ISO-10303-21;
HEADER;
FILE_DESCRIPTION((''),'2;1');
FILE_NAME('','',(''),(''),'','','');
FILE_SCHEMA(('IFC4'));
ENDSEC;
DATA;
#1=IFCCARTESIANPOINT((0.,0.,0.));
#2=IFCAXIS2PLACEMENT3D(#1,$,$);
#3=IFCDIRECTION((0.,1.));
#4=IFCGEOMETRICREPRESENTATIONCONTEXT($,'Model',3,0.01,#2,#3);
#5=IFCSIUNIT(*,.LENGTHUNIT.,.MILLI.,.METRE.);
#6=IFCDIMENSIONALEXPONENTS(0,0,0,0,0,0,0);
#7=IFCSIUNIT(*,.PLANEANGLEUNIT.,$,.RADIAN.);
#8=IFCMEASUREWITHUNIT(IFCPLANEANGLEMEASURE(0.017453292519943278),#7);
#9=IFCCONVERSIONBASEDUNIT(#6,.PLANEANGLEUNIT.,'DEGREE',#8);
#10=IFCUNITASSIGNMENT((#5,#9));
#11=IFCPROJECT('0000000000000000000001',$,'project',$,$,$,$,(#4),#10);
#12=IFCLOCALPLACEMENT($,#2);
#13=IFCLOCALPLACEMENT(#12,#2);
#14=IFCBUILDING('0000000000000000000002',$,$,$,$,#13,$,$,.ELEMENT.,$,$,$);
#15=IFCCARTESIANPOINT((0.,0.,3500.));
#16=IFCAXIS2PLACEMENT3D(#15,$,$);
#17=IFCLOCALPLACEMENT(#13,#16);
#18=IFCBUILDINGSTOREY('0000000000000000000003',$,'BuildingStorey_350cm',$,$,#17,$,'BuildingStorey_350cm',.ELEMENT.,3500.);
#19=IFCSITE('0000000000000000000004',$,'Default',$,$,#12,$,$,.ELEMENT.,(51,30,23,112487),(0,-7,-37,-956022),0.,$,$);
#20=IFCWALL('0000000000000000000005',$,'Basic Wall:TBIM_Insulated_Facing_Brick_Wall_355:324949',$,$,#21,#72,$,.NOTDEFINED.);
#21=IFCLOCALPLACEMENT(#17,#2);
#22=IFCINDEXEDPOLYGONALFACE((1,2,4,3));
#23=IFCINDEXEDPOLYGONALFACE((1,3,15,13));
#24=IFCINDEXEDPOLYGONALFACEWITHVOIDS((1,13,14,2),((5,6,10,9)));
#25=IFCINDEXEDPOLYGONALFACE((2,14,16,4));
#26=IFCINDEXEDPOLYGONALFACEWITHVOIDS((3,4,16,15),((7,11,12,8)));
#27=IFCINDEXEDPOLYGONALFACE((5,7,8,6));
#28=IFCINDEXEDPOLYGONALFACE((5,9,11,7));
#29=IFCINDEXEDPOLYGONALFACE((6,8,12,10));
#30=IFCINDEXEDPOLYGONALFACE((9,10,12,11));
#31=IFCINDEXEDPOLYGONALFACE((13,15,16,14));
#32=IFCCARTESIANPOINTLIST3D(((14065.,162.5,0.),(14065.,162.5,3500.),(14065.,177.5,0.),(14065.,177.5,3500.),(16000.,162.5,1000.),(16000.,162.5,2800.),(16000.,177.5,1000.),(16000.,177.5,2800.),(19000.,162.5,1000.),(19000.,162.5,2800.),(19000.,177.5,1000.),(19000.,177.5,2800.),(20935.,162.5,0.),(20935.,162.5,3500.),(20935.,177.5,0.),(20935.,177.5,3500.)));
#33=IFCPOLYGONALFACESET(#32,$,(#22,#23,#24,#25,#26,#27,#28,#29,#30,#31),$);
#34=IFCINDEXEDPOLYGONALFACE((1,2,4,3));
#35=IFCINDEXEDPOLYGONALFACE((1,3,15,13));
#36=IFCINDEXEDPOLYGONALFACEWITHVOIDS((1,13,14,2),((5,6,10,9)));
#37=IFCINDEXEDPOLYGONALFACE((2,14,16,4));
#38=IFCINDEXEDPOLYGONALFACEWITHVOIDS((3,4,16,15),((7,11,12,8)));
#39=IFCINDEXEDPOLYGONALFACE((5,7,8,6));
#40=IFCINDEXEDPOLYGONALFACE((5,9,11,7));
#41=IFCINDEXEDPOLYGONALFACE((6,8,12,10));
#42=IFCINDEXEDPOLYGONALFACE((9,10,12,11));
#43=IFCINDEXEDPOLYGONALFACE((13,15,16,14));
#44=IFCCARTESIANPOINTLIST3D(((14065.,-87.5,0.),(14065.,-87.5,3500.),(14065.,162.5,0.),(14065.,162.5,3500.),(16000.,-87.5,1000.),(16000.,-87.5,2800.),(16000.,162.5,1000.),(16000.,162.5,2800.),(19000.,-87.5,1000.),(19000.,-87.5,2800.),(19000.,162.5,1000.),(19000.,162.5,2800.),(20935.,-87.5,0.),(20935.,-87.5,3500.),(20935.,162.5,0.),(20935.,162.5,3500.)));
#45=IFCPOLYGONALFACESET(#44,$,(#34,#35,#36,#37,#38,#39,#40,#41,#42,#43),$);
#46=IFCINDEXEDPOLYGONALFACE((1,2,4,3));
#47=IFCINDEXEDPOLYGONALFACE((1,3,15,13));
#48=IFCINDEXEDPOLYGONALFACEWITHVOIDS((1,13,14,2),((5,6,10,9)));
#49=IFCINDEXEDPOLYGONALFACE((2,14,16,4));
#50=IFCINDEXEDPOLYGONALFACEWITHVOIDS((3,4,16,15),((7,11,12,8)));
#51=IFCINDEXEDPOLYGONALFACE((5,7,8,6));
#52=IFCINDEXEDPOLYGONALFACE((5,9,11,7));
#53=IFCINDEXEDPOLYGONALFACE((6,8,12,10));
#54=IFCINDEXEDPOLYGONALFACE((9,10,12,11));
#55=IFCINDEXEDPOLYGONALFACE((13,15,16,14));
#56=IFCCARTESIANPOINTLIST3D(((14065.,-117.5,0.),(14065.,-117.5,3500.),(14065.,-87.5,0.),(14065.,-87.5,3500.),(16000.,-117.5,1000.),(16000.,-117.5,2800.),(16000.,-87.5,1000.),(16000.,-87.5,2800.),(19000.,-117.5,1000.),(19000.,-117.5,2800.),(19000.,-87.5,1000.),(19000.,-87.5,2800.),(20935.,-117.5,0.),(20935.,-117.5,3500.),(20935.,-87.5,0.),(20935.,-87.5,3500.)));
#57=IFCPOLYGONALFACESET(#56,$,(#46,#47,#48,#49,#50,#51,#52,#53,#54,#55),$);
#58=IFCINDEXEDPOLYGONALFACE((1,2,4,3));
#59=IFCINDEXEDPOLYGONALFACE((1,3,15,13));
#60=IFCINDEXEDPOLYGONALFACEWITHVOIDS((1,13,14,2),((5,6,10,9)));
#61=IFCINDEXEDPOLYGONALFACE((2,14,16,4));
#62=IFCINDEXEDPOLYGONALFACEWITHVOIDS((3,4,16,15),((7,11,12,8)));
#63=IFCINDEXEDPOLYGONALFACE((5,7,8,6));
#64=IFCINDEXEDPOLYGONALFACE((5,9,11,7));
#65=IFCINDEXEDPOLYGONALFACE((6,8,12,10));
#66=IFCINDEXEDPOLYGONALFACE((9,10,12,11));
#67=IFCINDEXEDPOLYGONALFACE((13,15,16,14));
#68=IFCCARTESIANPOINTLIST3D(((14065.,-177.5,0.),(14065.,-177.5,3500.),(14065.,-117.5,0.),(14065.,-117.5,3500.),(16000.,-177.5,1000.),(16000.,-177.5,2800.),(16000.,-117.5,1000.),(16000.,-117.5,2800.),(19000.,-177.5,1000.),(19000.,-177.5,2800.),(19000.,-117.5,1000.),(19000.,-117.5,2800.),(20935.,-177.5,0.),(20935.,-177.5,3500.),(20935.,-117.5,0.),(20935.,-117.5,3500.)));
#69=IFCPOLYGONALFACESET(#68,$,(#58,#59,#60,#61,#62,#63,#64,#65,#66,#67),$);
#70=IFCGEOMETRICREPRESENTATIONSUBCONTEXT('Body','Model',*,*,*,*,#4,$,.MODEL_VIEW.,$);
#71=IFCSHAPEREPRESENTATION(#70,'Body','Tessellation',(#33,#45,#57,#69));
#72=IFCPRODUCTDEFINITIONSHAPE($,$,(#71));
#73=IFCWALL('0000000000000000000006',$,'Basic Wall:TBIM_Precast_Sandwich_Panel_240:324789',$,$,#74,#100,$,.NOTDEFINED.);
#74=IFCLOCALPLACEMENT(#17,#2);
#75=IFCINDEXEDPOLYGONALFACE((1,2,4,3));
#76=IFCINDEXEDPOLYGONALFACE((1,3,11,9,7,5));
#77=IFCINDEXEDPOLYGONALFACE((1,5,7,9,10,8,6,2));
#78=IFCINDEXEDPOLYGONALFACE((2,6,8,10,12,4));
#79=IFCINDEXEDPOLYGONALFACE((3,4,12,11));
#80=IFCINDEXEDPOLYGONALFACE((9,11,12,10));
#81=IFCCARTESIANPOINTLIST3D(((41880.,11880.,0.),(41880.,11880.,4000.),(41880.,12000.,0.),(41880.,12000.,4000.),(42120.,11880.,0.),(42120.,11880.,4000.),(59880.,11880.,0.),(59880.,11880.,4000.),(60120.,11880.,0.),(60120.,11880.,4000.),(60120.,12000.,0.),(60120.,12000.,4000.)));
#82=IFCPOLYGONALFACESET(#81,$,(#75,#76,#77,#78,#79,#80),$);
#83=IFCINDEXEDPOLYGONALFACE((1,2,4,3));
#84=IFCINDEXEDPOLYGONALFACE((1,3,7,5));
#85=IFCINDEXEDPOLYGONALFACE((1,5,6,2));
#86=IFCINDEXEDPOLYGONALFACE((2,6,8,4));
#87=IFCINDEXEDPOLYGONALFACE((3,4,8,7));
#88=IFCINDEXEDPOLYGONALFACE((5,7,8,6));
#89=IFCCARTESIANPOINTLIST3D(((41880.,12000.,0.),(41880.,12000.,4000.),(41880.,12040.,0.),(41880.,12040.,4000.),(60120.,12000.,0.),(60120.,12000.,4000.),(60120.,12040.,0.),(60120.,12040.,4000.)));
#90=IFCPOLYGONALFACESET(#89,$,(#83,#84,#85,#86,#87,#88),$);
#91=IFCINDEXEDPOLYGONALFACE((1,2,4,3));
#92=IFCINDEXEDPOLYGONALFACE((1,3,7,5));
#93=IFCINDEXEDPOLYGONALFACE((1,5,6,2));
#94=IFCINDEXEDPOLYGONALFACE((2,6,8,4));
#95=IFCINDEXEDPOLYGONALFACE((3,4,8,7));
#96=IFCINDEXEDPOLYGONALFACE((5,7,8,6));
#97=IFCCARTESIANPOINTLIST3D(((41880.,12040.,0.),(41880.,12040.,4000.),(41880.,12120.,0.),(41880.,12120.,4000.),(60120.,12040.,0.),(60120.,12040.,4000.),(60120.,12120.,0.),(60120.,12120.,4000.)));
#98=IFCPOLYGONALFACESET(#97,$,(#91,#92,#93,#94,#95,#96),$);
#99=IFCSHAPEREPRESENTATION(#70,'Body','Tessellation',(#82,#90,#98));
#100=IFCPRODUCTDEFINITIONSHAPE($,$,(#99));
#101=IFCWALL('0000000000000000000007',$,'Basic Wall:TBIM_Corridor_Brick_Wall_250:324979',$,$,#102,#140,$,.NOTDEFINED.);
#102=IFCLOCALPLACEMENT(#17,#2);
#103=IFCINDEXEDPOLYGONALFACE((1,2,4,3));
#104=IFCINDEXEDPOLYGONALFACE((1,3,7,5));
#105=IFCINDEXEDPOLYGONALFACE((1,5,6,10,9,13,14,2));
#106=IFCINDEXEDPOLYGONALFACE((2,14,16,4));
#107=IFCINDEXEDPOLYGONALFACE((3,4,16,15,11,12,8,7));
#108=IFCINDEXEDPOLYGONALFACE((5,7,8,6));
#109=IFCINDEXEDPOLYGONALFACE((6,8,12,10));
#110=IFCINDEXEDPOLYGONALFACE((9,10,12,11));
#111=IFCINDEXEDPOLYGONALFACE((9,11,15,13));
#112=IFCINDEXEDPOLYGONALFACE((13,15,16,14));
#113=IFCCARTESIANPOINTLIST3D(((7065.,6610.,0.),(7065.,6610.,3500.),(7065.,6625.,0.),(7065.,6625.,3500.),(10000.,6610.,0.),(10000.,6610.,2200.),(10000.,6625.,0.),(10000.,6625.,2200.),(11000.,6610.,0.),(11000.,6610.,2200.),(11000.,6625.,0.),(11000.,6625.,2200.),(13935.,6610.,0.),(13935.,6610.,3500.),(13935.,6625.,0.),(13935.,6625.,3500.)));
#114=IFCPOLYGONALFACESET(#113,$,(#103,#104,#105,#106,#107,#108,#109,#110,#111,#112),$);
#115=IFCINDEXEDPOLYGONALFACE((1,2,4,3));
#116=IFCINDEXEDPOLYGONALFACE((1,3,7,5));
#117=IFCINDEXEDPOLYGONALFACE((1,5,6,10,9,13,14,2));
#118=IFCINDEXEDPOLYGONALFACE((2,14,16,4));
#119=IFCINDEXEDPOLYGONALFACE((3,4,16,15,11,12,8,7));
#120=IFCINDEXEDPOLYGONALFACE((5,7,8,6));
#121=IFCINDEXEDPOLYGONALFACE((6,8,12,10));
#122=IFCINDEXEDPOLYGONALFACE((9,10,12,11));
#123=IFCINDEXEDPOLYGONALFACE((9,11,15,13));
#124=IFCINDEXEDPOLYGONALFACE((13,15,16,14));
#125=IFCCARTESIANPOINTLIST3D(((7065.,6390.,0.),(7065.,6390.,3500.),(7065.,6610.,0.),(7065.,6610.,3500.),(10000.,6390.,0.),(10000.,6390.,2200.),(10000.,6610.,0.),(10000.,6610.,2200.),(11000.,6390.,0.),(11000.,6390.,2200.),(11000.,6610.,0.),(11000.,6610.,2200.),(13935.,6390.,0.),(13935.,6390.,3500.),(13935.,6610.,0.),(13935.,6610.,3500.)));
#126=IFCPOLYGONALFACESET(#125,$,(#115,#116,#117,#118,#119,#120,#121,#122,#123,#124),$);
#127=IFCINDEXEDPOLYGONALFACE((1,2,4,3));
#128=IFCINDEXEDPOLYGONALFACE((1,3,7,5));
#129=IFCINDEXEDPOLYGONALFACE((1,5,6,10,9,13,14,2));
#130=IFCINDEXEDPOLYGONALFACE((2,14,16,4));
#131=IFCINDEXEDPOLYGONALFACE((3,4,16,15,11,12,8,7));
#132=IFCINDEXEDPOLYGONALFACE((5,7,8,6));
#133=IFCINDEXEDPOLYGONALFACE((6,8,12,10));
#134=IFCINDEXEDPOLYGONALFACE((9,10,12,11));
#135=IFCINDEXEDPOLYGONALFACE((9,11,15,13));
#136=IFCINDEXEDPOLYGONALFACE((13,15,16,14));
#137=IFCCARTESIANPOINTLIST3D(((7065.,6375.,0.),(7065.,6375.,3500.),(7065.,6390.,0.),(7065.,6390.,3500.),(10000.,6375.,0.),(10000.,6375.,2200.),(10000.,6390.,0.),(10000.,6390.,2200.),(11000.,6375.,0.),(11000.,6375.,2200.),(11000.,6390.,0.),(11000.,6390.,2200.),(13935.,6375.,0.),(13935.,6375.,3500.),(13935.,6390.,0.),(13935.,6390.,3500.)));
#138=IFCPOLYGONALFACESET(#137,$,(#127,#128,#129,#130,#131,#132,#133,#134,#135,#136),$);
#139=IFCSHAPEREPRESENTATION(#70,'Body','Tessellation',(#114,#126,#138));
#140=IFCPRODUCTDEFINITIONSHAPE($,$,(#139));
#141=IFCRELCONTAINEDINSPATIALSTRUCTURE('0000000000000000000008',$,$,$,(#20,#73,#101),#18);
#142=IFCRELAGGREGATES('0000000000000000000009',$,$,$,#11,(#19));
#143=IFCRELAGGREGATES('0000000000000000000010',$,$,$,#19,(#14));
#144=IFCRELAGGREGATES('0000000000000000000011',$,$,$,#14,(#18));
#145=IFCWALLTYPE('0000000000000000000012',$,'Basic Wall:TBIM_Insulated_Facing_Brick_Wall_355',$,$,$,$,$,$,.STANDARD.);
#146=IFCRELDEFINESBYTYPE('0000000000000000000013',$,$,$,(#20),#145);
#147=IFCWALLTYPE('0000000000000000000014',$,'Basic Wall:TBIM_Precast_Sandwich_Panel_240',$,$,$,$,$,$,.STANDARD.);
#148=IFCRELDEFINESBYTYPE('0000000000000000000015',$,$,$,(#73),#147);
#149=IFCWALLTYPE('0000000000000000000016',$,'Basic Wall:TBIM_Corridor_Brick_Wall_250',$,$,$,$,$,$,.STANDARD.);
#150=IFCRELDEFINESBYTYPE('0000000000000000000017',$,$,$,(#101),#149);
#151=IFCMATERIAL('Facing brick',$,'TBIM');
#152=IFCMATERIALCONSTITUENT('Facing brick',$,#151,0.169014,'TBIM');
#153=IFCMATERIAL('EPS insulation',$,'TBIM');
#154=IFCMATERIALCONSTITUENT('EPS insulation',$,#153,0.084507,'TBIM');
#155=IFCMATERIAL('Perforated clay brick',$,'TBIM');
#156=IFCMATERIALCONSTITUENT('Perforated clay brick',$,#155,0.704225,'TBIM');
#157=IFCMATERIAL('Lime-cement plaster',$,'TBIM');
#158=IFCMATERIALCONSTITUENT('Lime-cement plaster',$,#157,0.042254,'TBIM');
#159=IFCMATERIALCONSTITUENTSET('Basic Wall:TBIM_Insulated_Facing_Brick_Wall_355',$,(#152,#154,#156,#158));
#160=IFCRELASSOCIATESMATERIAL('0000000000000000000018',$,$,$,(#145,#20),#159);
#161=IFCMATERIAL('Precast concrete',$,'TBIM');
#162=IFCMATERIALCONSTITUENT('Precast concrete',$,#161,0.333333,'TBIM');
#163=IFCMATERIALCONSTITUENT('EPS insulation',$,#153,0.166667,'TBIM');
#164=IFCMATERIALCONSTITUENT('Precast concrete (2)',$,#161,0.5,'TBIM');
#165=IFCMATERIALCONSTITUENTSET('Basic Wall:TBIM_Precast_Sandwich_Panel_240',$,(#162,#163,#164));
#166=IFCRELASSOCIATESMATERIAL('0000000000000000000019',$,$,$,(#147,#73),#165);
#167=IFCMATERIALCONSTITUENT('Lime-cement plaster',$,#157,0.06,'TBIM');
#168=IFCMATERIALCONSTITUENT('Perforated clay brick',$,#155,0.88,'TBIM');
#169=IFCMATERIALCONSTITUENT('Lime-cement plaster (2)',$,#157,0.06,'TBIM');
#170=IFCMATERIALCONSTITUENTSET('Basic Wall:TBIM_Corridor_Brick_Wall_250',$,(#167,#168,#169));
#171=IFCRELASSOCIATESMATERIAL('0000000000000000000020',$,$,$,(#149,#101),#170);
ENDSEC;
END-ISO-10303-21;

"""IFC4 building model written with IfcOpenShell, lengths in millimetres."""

from ifc_helpers import new_model, entity, si_unit, converted_unit, direction, frame, origin, place, context, subcontext, project, spatial, indexed_curve, outline, extrude, material, constituent, constituent_set, type_object, element, save


model = new_model("IFC4")

# Units and contexts
model_context = context("Model", 3, precision=0.01, world=origin(), true_north=direction((0.0, 1.0)))
body_context = subcontext(model_context, "Body", "Model", "MODEL_VIEW")
ifc_project = project(units=[si_unit("LENGTHUNIT", "METRE", prefix="MILLI"), converted_unit("PLANEANGLEUNIT", "DEGREE", entity("IfcPlaneAngleMeasure", 0.017453292519943278), si_unit("PLANEANGLEUNIT", "RADIAN"), dimensions=[0, 0, 0, 0, 0, 0, 0])], contexts=[model_context])

# Site, building, storey
site_placement = place(None, origin())
site = spatial("IfcSite", under=ifc_project, at=site_placement, Name="Default", CompositionType="ELEMENT", RefLatitude=(51, 30, 23, 112487), RefLongitude=(0, -7, -37, -956022), RefElevation=0.0)
building_placement = place(site_placement, origin())
building = spatial("IfcBuilding", under=site, at=building_placement, CompositionType="ELEMENT")
storey_placement = place(building_placement, frame((0.0, 0.0, 3500.0)))
storey = spatial("IfcBuildingStorey", under=building, at=storey_placement, Name="BuildingStorey_350cm", LongName="BuildingStorey_350cm", CompositionType="ELEMENT", Elevation=3500.0)

# Shared definitions
ifc_material_1 = material(Name="Lime-cement plaster", Category="TBIM")

# Wall, opening
ifc_material_2 = material(Name="Facing brick", Category="TBIM")
ifc_constituent_1 = constituent(ifc_material_2, Name="Facing brick", Category="TBIM", fraction=0.169014)
ifc_material_3 = material(Name="EPS insulation", Category="TBIM")
ifc_constituent_2 = constituent(ifc_material_3, Name="EPS insulation", Category="TBIM", fraction=0.084507)
ifc_material_4 = material(Name="Perforated clay brick", Category="TBIM")
ifc_constituent_3 = constituent(ifc_material_4, Name="Perforated clay brick", Category="TBIM", fraction=0.704225)
ifc_constituent_4 = constituent(ifc_material_1, Name="Lime-cement plaster", Category="TBIM", fraction=0.042254)
ifc_constituent_set_1 = constituent_set(constituents=[ifc_constituent_1, ifc_constituent_2, ifc_constituent_3, ifc_constituent_4], Name="Basic Wall:TBIM_Insulated_Facing_Brick_Wall_355")
wall_type_1 = type_object("IfcWallType", Name="Basic Wall:TBIM_Insulated_Facing_Brick_Wall_355", PredefinedType="STANDARD", material=ifc_constituent_set_1)
wall_1_placement = place(storey_placement, frame((14065.0, 0.0, 0.0)))
wall_1 = element("IfcWall", 1, at=wall_1_placement, inside=storey, type_object=wall_type_1, material=ifc_constituent_set_1, Name="Basic Wall:TBIM_Insulated_Facing_Brick_Wall_355:324949", PredefinedType="NOTDEFINED", context=body_context, shape_type="SweptSolid", body=[
    extrude(outline(indexed_curve([(-1750.0, -3435.0), (1750.0, -3435.0), (1750.0, 3435.0), (-1750.0, 3435.0), (-1750.0, -3435.0)], self_intersect=False), holes=[indexed_curve([(-750.0, -1500.0), (-750.0, 1500.0), (1050.0, 1500.0), (1050.0, -1500.0), (-750.0, -1500.0)], self_intersect=False)]), frame((3435.0, 162.5, 1750.0), z_axis=(0.0, 1.0, 0.0), x_axis=(0.0, 0.0, 1.0)), (0.0, 0.0, 1.0), 15.0),
    extrude(outline(indexed_curve([(-1750.0, -3435.0), (1750.0, -3435.0), (1750.0, 3435.0), (-1750.0, 3435.0), (-1750.0, -3435.0)], self_intersect=False), holes=[indexed_curve([(-750.0, -1500.0), (-750.0, 1500.0), (1050.0, 1500.0), (1050.0, -1500.0), (-750.0, -1500.0)], self_intersect=False)]), frame((3435.0, -87.5, 1750.0), z_axis=(0.0, 1.0, 0.0), x_axis=(0.0, 0.0, 1.0)), (0.0, 0.0, 1.0), 250.0),
    extrude(outline(indexed_curve([(-1750.0, -3435.0), (1750.0, -3435.0), (1750.0, 3435.0), (-1750.0, 3435.0), (-1750.0, -3435.0)], self_intersect=False), holes=[indexed_curve([(-750.0, -1500.0), (-750.0, 1500.0), (1050.0, 1500.0), (1050.0, -1500.0), (-750.0, -1500.0)], self_intersect=False)]), frame((3435.0, -117.5, 1750.0), z_axis=(0.0, 1.0, 0.0), x_axis=(0.0, 0.0, 1.0)), (0.0, 0.0, 1.0), 30.0),
    extrude(outline(indexed_curve([(-1750.0, -3435.0), (1750.0, -3435.0), (1750.0, 3435.0), (-1750.0, 3435.0), (-1750.0, -3435.0)], self_intersect=False), holes=[indexed_curve([(1050.0, -1500.0), (-750.0, -1500.0), (-750.0, 1500.0), (1050.0, 1500.0), (1050.0, -1500.0)], self_intersect=False)]), frame((3435.0, -177.5, 1750.0), z_axis=(0.0, 1.0, 0.0), x_axis=(0.0, 0.0, 1.0)), (0.0, 0.0, 1.0), 60.0),
])
opening_1_placement = place(wall_1_placement, frame((1935.0, -177.5, 1000.0)))
element("IfcOpeningElement", 2, at=opening_1_placement, cuts=wall_1, PredefinedType="OPENING", context=body_context, shape_type="SweptSolid", body=[
    extrude(outline(indexed_curve([(1800.0, 0.0), (1800.0, 3000.0), (0.0, 3000.0), (0.0, 0.0), (1800.0, 0.0)], self_intersect=False)), frame((0.0, 0.0, 0.0), z_axis=(0.0, 1.0, 0.0), x_axis=(0.0, 0.0, 1.0)), (0.0, 0.0, 1.0), 355.0),
])

# Wall
ifc_material_5 = material(Name="Precast concrete", Category="TBIM")
ifc_constituent_5 = constituent(ifc_material_5, Name="Precast concrete", Category="TBIM", fraction=0.333333)
ifc_constituent_6 = constituent(ifc_material_3, Name="EPS insulation", Category="TBIM", fraction=0.166667)
ifc_constituent_7 = constituent(ifc_material_5, Name="Precast concrete (2)", Category="TBIM", fraction=0.5)
ifc_constituent_set_2 = constituent_set(constituents=[ifc_constituent_5, ifc_constituent_6, ifc_constituent_7], Name="Basic Wall:TBIM_Precast_Sandwich_Panel_240")
wall_type_2 = type_object("IfcWallType", Name="Basic Wall:TBIM_Precast_Sandwich_Panel_240", PredefinedType="STANDARD", material=ifc_constituent_set_2)
wall_2_placement = place(storey_placement, frame((41880.0, 12000.0, 0.0)))
element("IfcWall", 3, at=wall_2_placement, inside=storey, type_object=wall_type_2, material=ifc_constituent_set_2, Name="Basic Wall:TBIM_Precast_Sandwich_Panel_240:324789", PredefinedType="NOTDEFINED", context=body_context, shape_type="SweptSolid", body=[
    extrude(outline(indexed_curve([(-8880.0, -40.0), (8880.0, -40.0), (9120.0, -40.0), (9120.0, 80.0), (-9120.0, 80.0), (-9120.0, -40.0), (-8880.0, -40.0)], self_intersect=False)), frame((9120.0, -80.0, 0.0)), (0.0, 0.0, 1.0), 4000.0),
    extrude(outline(indexed_curve([(-9120.0, -20.0), (9120.0, -20.0), (9120.0, 20.0), (-9120.0, 20.0), (-9120.0, -20.0)], self_intersect=False)), frame((9120.0, 20.0, 0.0)), (0.0, 0.0, 1.0), 4000.0),
    extrude(outline(indexed_curve([(-40.0, -9120.0), (40.0, -9120.0), (40.0, 9120.0), (-40.0, 9120.0), (-40.0, -9120.0)], self_intersect=False)), frame((9120.0, 80.0, 0.0), z_axis=(0.0, 0.0, 1.0), x_axis=(0.0, -1.0, 0.0)), (0.0, 0.0, 1.0), 4000.0),
])

# Wall, opening
ifc_constituent_8 = constituent(ifc_material_1, Name="Lime-cement plaster", Category="TBIM", fraction=0.06)
ifc_constituent_9 = constituent(ifc_material_4, Name="Perforated clay brick", Category="TBIM", fraction=0.88)
ifc_constituent_10 = constituent(ifc_material_1, Name="Lime-cement plaster (2)", Category="TBIM", fraction=0.06)
ifc_constituent_set_3 = constituent_set(constituents=[ifc_constituent_8, ifc_constituent_9, ifc_constituent_10], Name="Basic Wall:TBIM_Corridor_Brick_Wall_250")
wall_type_3 = type_object("IfcWallType", Name="Basic Wall:TBIM_Corridor_Brick_Wall_250", PredefinedType="STANDARD", material=ifc_constituent_set_3)
wall_3_placement = place(storey_placement, frame((7065.0, 6500.0, 0.0)))
wall_3 = element("IfcWall", 4, at=wall_3_placement, inside=storey, type_object=wall_type_3, material=ifc_constituent_set_3, Name="Basic Wall:TBIM_Corridor_Brick_Wall_250:324979", PredefinedType="NOTDEFINED", context=body_context, shape_type="SweptSolid", body=[
    extrude(outline(indexed_curve([(-1425.0, -3435.0), (2075.0, -3435.0), (2075.0, 3435.0), (-1425.0, 3435.0), (-1425.0, 500.0), (775.0, 500.0), (775.0, -500.0), (-1425.0, -500.0), (-1425.0, -3435.0)], self_intersect=False)), frame((3435.0, 110.0, 1425.0), z_axis=(0.0, 1.0, 0.0), x_axis=(0.0, 0.0, 1.0)), (0.0, 0.0, 1.0), 15.0),
    extrude(outline(indexed_curve([(-1425.0, -3435.0), (2075.0, -3435.0), (2075.0, 3435.0), (-1425.0, 3435.0), (-1425.0, 500.0), (775.0, 500.0), (775.0, -500.0), (-1425.0, -500.0), (-1425.0, -3435.0)], self_intersect=False)), frame((3435.0, -110.0, 1425.0), z_axis=(0.0, 1.0, 0.0), x_axis=(0.0, 0.0, 1.0)), (0.0, 0.0, 1.0), 220.0),
    extrude(outline(indexed_curve([(-2075.0, -3435.0), (1425.0, -3435.0), (1425.0, -500.0), (-775.0, -500.0), (-775.0, 500.0), (1425.0, 500.0), (1425.0, 3435.0), (-2075.0, 3435.0), (-2075.0, -3435.0)], self_intersect=False)), frame((3435.0, -125.0, 1425.0), z_axis=(0.0, 1.0, 0.0), x_axis=(0.0, 0.0, -1.0)), (0.0, 0.0, 1.0), 15.0),
])
opening_2_placement = place(wall_3_placement, frame((2935.0, -125.0, 0.0)))
element("IfcOpeningElement", 5, at=opening_2_placement, cuts=wall_3, PredefinedType="OPENING", context=body_context, shape_type="SweptSolid", body=[
    extrude(outline(indexed_curve([(0.0, 1000.0), (0.0, 0.0), (2200.0, 0.0), (2200.0, 1000.0), (0.0, 1000.0)], self_intersect=False)), frame((0.0, 0.0, 0.0), z_axis=(0.0, 1.0, 0.0), x_axis=(0.0, 0.0, 1.0)), (0.0, 0.0, 1.0), 250.0),
])

save(model, "model.ifc")
